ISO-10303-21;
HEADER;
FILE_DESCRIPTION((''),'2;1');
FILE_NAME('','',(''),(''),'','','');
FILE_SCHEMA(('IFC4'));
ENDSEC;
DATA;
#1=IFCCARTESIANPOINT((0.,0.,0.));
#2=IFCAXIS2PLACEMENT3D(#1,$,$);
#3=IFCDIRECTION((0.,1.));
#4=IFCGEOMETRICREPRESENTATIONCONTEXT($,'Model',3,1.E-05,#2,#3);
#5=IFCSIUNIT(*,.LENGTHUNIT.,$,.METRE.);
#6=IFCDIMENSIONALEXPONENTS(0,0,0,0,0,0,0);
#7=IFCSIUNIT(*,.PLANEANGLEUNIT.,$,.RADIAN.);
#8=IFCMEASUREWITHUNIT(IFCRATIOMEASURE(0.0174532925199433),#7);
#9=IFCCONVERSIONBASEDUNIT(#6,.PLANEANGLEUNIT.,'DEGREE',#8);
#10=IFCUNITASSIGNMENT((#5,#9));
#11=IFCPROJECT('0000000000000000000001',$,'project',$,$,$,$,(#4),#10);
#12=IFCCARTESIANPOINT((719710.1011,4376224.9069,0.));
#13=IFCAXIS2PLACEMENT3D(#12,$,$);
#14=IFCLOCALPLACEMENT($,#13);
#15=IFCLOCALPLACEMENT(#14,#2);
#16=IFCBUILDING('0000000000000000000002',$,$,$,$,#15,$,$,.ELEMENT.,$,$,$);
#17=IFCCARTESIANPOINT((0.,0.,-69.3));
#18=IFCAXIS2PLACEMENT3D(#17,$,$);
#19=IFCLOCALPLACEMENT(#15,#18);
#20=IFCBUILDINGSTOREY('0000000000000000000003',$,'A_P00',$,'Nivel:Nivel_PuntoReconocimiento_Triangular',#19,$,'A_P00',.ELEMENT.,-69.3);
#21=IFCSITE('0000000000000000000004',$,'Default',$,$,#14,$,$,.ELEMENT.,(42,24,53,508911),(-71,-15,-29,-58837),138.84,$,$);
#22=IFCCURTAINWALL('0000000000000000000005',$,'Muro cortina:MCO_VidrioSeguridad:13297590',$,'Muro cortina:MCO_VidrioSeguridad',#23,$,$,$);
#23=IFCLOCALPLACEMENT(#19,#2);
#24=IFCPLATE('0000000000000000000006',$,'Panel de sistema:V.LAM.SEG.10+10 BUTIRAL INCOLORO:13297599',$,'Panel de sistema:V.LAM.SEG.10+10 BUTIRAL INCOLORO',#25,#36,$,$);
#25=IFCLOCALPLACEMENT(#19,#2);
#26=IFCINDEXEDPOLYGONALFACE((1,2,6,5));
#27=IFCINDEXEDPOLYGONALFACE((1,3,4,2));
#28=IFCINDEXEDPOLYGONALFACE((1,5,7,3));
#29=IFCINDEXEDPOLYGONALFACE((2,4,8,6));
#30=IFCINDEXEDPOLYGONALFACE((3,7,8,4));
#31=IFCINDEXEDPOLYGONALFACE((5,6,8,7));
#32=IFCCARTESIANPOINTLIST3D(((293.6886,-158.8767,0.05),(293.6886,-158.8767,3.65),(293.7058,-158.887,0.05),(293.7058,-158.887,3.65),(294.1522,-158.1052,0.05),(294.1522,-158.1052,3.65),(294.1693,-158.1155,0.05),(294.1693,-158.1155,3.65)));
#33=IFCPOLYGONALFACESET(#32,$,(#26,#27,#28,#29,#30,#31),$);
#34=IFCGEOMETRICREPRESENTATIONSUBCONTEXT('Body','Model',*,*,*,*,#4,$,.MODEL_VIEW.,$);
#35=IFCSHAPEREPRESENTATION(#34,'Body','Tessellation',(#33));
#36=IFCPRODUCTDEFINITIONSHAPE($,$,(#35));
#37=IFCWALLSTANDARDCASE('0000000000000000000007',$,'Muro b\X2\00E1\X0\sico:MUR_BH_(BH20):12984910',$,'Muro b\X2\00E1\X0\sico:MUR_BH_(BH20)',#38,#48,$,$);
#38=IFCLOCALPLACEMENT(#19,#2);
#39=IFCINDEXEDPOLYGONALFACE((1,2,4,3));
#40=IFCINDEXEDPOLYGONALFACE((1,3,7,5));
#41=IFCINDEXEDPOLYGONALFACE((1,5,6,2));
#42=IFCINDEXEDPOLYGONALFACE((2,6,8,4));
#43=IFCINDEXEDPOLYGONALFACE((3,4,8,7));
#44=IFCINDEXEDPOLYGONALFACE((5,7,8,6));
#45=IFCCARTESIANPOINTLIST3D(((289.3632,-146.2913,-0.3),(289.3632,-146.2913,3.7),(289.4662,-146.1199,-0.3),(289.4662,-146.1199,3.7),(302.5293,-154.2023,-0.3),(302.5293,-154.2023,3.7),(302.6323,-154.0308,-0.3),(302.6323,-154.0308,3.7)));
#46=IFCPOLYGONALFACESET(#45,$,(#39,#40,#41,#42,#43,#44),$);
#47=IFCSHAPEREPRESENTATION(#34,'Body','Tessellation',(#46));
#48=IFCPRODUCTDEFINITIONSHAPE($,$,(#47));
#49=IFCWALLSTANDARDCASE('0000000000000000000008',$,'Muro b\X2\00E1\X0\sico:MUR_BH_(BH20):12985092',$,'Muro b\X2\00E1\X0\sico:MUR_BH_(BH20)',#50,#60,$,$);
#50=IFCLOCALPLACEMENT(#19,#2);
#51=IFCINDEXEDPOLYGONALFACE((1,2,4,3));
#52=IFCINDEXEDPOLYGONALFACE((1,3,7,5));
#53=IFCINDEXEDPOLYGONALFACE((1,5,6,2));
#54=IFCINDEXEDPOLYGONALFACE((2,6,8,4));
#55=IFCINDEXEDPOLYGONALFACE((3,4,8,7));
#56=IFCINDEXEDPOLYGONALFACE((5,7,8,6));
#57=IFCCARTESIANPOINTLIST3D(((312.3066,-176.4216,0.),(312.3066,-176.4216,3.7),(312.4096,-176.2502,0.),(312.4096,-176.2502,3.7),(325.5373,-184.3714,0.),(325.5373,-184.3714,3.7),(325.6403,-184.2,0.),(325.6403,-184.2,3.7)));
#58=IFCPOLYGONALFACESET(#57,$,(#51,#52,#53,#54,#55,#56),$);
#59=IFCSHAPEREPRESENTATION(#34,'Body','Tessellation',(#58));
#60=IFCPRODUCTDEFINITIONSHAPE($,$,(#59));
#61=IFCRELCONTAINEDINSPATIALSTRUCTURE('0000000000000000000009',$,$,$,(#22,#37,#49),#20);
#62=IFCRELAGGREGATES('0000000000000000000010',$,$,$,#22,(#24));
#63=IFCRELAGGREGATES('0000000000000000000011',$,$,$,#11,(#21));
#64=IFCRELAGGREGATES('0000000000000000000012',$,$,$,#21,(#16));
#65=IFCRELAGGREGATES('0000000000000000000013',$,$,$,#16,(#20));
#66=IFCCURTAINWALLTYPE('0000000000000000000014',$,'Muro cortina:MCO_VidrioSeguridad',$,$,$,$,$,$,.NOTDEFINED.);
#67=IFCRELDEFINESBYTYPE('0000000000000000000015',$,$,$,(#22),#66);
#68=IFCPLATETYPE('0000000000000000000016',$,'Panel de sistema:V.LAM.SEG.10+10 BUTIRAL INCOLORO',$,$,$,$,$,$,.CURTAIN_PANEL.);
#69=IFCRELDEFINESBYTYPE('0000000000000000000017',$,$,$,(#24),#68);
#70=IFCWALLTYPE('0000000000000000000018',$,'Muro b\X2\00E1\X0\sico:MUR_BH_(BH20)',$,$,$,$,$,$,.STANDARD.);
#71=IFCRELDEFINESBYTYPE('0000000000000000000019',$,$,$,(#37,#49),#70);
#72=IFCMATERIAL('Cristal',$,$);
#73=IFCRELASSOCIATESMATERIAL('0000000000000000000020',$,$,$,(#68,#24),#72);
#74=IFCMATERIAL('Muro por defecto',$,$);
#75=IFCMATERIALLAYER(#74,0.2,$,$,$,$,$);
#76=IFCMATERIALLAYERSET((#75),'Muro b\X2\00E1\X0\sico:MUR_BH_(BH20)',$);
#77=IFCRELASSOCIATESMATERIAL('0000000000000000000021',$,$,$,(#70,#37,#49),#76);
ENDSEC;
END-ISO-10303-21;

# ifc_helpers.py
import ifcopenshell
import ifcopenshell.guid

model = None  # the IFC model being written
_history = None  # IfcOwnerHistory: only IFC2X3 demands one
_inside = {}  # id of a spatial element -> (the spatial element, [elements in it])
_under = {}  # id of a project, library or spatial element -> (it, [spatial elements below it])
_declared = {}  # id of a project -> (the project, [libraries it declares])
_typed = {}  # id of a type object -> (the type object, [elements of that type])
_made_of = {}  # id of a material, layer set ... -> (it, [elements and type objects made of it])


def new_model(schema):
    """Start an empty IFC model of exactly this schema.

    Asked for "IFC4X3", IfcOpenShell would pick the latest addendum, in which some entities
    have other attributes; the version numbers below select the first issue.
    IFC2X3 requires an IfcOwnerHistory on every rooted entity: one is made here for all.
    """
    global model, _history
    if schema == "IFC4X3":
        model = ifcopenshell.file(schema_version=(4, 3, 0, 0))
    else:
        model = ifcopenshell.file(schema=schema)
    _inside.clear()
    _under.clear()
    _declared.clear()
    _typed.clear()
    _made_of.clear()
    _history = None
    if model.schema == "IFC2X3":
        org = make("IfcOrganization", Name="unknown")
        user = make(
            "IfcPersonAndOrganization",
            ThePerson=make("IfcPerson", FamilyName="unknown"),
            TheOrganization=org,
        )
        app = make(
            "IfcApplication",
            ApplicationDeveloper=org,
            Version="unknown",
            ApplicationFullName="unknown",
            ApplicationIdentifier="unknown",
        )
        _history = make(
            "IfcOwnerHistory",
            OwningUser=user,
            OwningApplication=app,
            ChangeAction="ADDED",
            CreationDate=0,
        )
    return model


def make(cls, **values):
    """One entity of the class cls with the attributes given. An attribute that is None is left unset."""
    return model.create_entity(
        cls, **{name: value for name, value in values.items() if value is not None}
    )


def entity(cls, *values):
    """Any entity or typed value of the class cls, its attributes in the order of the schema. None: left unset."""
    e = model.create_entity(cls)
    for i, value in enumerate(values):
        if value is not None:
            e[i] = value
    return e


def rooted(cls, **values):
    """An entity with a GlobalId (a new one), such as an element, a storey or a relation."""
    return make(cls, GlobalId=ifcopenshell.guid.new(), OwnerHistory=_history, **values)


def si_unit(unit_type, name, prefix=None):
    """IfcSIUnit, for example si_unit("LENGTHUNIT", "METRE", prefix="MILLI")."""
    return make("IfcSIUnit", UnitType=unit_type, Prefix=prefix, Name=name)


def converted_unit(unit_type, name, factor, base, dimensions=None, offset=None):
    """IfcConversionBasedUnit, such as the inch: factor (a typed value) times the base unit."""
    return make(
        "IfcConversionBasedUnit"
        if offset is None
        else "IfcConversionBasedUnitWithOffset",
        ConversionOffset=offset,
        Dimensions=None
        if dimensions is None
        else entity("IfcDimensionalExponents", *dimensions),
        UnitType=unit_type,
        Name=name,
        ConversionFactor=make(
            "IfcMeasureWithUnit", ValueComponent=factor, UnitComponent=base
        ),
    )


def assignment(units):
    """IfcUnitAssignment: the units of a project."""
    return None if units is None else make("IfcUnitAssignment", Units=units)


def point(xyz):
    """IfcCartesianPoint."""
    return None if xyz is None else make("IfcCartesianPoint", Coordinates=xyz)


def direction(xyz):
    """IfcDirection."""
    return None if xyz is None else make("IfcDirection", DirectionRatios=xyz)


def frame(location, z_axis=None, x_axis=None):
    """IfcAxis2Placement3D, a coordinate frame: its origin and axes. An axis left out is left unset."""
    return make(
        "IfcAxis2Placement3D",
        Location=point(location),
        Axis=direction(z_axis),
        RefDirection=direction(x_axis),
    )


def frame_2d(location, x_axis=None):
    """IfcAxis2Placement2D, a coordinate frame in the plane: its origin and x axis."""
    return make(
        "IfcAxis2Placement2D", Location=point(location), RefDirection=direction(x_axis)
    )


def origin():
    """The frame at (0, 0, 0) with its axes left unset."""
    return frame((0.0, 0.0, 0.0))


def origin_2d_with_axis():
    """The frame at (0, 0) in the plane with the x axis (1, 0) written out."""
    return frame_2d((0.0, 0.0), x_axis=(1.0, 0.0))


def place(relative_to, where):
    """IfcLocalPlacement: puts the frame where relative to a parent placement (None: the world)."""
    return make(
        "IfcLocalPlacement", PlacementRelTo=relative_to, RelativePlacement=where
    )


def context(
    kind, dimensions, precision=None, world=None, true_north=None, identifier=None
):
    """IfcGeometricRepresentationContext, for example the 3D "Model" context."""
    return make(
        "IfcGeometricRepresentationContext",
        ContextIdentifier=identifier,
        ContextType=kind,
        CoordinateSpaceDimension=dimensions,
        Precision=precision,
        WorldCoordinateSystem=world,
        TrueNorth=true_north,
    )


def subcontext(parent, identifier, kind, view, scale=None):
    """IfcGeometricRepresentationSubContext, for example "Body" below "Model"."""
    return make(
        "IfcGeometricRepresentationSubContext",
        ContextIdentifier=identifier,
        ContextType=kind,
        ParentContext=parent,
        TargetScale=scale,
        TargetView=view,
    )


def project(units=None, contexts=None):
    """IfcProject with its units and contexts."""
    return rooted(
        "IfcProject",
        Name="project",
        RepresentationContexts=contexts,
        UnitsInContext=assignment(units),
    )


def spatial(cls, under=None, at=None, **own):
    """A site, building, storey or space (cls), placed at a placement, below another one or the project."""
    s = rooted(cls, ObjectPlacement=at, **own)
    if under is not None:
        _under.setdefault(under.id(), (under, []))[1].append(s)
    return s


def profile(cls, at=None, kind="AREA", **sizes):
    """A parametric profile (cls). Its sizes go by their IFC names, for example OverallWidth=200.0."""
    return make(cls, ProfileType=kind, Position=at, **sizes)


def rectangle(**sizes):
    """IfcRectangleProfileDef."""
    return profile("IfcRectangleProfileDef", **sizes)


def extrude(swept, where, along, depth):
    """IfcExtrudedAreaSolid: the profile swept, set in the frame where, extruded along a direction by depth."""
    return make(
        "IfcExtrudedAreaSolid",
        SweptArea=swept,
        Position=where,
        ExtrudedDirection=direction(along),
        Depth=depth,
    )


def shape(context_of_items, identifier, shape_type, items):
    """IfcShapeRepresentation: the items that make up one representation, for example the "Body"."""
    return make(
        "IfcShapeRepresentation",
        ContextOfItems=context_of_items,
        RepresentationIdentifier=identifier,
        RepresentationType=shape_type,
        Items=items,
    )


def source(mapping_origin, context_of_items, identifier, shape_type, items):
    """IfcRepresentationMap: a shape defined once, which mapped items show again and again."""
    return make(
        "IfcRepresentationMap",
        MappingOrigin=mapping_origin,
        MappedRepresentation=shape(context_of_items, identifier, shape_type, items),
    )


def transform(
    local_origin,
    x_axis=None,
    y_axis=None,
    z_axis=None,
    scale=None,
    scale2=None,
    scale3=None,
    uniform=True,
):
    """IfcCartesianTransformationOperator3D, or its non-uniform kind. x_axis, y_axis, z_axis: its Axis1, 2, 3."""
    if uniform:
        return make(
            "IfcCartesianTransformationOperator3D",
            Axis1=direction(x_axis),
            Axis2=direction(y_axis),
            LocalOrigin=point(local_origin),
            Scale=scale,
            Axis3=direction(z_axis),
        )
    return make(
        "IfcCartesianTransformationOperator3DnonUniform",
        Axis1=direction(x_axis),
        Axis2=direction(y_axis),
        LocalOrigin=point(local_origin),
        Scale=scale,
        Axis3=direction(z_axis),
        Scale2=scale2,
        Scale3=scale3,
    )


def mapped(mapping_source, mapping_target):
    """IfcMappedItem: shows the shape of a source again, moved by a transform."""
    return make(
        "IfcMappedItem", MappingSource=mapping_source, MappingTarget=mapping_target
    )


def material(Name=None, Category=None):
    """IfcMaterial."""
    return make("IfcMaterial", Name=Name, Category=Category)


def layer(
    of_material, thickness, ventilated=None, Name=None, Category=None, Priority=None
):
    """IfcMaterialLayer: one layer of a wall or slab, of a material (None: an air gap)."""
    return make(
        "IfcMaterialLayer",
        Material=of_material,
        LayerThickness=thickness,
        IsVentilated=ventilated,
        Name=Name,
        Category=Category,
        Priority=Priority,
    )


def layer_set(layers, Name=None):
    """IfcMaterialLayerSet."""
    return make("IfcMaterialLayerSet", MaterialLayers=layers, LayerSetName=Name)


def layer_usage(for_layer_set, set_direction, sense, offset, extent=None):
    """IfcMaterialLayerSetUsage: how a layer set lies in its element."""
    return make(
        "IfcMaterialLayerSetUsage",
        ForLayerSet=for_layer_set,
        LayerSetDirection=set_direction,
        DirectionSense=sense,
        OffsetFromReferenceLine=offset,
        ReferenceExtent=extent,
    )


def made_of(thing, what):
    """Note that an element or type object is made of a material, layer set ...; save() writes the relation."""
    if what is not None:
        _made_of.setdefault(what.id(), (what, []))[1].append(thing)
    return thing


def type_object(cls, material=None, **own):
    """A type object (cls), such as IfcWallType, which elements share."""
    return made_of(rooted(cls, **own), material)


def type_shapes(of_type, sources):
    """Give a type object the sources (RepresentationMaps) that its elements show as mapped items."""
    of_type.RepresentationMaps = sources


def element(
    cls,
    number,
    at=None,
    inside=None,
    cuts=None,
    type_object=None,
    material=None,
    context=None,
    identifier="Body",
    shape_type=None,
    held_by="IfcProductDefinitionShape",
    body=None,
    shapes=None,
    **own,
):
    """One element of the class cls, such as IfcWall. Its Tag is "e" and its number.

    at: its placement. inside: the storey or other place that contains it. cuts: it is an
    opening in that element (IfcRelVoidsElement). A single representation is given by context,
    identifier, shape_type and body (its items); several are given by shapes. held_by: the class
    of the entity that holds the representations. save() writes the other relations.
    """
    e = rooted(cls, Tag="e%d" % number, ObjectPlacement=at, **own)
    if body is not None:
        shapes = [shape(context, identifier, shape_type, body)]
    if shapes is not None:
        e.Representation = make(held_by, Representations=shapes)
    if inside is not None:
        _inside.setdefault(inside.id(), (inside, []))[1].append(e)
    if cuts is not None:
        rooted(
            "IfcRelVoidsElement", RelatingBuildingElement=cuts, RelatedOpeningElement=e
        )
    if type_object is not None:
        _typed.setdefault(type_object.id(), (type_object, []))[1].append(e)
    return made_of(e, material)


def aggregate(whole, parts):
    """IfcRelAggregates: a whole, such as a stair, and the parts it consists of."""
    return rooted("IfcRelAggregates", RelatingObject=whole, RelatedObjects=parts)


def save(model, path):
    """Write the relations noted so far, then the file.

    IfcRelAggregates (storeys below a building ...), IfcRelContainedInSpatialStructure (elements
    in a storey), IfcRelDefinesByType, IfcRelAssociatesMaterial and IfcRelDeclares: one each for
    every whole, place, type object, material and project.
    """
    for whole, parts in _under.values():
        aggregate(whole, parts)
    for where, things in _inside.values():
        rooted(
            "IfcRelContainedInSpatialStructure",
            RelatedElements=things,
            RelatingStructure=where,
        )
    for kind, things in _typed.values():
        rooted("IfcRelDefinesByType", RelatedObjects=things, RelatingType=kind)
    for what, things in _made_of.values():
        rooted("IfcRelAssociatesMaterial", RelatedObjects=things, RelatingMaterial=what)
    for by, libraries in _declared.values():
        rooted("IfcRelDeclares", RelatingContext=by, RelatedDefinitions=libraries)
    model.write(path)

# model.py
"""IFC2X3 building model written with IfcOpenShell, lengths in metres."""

from ifc_helpers import new_model, entity, si_unit, converted_unit, direction, frame, frame_2d, origin, origin_2d_with_axis, place, context, subcontext, project, spatial, rectangle, extrude, source, transform, mapped, material, layer, layer_set, layer_usage, type_object, type_shapes, element, aggregate, save


model = new_model("IFC2X3")

# Units and contexts
model_context = context("Model", 3, precision=1e-05, world=origin(), true_north=direction((0.0, 1.0)))
body_context = subcontext(model_context, "Body", "Model", "MODEL_VIEW")
ifc_project = project(units=[si_unit("LENGTHUNIT", "METRE"), converted_unit("PLANEANGLEUNIT", "DEGREE", entity("IfcRatioMeasure", 0.0174532925199433), si_unit("PLANEANGLEUNIT", "RADIAN"), dimensions=[0, 0, 0, 0, 0, 0, 0])], contexts=[model_context])

# Site, building, storey
site_placement = place(None, frame((719710.1011, 4376224.9069, 0.0)))
site = spatial("IfcSite", under=ifc_project, at=site_placement, Name="Default", CompositionType="ELEMENT", RefLatitude=(42, 24, 53, 508911), RefLongitude=(-71, -15, -29, -58837), RefElevation=138.84)
building_placement = place(site_placement, origin())
building = spatial("IfcBuilding", under=site, at=building_placement, CompositionType="ELEMENT")
storey_placement = place(building_placement, frame((0.0, 0.0, -69.3)))
storey = spatial("IfcBuildingStorey", under=building, at=storey_placement, Name="A_P00", ObjectType="Nivel:Nivel_PuntoReconocimiento_Triangular", LongName="A_P00", CompositionType="ELEMENT", Elevation=-69.3)

# Shared definitions
curtain_wall_type = type_object("IfcCurtainWallType", Name="Muro cortina:MCO_VidrioSeguridad", PredefinedType="NOTDEFINED")
ifc_material_1 = material(Name="Cristal")

# Curtain wall, plate
curtain_wall_1_placement = place(storey_placement, frame((0.0, 0.0, 69.3)))
curtain_wall_1 = element("IfcCurtainWall", 1, at=curtain_wall_1_placement, inside=storey, type_object=curtain_wall_type, Name="Muro cortina:MCO_VidrioSeguridad:13297590", ObjectType="Muro cortina:MCO_VidrioSeguridad")
plate_type_1 = type_object("IfcPlateType", Name="Panel de sistema:V.LAM.SEG.10+10 BUTIRAL INCOLORO", PredefinedType="CURTAIN_PANEL", material=ifc_material_1)
shared_shape_1 = source(origin(), body_context, "Body", "SweptSolid", [
    extrude(rectangle(XDim=0.02, YDim=0.9, at=origin_2d_with_axis()), frame((0.0, 0.0, 0.0), z_axis=(0.0, 0.0, 1.0), x_axis=(0.0, 1.0, 0.0)), (0.0, 0.0, 1.0), 3.6),
])
type_shapes(plate_type_1, [shared_shape_1])
plate_1_placement = place(curtain_wall_1_placement, frame((293.929, -158.4961, -69.25), z_axis=(0.0, 0.0, 1.0), x_axis=(0.515038, 0.857167, 0.0)))
plate_1 = element("IfcPlate", 2, at=plate_1_placement, type_object=plate_type_1, material=ifc_material_1, Name="Panel de sistema:V.LAM.SEG.10+10 BUTIRAL INCOLORO:13297599", ObjectType="Panel de sistema:V.LAM.SEG.10+10 BUTIRAL INCOLORO", context=body_context, shape_type="MappedRepresentation", body=[
    mapped(shared_shape_1, transform((0.0, 0.0, 0.0), scale=1.0)),
])
aggregate(curtain_wall_1, [plate_1])

# Walls
ifc_material_2 = material(Name="Muro por defecto")
ifc_layer_1 = layer(ifc_material_2, 0.2)
ifc_layer_set_1 = layer_set([ifc_layer_1], Name="Muro básico:MUR_BH_(BH20)")
ifc_layer_usage_1 = layer_usage(ifc_layer_set_1, "AXIS2", "NEGATIVE", 0.1)
wall_type = type_object("IfcWallType", Name="Muro básico:MUR_BH_(BH20)", PredefinedType="STANDARD", material=ifc_layer_set_1)
wall_1_placement = place(storey_placement, frame((302.5808, -154.1166, -0.3), z_axis=(0.0, 0.0, 1.0), x_axis=(-0.857167, 0.515038, 0.0)))
element("IfcWallStandardCase", 3, at=wall_1_placement, inside=storey, type_object=wall_type, material=ifc_layer_usage_1, Name="Muro básico:MUR_BH_(BH20):12984910", ObjectType="Muro básico:MUR_BH_(BH20)", context=body_context, shape_type="SweptSolid", body=[
    extrude(rectangle(XDim=15.36, YDim=0.2, at=frame_2d((7.68, 0.0), x_axis=(-1.0, 0.0))), origin(), (0.0, 0.0, 1.0), 4.0),
])
ifc_layer_usage_2 = layer_usage(ifc_layer_set_1, "AXIS2", "NEGATIVE", 0.1)
wall_2_placement = place(storey_placement, frame((312.3581, -176.3359, 0.0), z_axis=(0.0, 0.0, 1.0), x_axis=(0.857167, -0.515038, 0.0)))
element("IfcWallStandardCase", 4, at=wall_2_placement, inside=storey, type_object=wall_type, material=ifc_layer_usage_2, Name="Muro básico:MUR_BH_(BH20):12985092", ObjectType="Muro básico:MUR_BH_(BH20)", context=body_context, shape_type="SweptSolid", body=[
    extrude(rectangle(XDim=15.4354, YDim=0.2, at=frame_2d((7.7177, 0.0), x_axis=(-1.0, 0.0))), origin(), (0.0, 0.0, 1.0), 3.7),
])

save(model, "model.ifc")
